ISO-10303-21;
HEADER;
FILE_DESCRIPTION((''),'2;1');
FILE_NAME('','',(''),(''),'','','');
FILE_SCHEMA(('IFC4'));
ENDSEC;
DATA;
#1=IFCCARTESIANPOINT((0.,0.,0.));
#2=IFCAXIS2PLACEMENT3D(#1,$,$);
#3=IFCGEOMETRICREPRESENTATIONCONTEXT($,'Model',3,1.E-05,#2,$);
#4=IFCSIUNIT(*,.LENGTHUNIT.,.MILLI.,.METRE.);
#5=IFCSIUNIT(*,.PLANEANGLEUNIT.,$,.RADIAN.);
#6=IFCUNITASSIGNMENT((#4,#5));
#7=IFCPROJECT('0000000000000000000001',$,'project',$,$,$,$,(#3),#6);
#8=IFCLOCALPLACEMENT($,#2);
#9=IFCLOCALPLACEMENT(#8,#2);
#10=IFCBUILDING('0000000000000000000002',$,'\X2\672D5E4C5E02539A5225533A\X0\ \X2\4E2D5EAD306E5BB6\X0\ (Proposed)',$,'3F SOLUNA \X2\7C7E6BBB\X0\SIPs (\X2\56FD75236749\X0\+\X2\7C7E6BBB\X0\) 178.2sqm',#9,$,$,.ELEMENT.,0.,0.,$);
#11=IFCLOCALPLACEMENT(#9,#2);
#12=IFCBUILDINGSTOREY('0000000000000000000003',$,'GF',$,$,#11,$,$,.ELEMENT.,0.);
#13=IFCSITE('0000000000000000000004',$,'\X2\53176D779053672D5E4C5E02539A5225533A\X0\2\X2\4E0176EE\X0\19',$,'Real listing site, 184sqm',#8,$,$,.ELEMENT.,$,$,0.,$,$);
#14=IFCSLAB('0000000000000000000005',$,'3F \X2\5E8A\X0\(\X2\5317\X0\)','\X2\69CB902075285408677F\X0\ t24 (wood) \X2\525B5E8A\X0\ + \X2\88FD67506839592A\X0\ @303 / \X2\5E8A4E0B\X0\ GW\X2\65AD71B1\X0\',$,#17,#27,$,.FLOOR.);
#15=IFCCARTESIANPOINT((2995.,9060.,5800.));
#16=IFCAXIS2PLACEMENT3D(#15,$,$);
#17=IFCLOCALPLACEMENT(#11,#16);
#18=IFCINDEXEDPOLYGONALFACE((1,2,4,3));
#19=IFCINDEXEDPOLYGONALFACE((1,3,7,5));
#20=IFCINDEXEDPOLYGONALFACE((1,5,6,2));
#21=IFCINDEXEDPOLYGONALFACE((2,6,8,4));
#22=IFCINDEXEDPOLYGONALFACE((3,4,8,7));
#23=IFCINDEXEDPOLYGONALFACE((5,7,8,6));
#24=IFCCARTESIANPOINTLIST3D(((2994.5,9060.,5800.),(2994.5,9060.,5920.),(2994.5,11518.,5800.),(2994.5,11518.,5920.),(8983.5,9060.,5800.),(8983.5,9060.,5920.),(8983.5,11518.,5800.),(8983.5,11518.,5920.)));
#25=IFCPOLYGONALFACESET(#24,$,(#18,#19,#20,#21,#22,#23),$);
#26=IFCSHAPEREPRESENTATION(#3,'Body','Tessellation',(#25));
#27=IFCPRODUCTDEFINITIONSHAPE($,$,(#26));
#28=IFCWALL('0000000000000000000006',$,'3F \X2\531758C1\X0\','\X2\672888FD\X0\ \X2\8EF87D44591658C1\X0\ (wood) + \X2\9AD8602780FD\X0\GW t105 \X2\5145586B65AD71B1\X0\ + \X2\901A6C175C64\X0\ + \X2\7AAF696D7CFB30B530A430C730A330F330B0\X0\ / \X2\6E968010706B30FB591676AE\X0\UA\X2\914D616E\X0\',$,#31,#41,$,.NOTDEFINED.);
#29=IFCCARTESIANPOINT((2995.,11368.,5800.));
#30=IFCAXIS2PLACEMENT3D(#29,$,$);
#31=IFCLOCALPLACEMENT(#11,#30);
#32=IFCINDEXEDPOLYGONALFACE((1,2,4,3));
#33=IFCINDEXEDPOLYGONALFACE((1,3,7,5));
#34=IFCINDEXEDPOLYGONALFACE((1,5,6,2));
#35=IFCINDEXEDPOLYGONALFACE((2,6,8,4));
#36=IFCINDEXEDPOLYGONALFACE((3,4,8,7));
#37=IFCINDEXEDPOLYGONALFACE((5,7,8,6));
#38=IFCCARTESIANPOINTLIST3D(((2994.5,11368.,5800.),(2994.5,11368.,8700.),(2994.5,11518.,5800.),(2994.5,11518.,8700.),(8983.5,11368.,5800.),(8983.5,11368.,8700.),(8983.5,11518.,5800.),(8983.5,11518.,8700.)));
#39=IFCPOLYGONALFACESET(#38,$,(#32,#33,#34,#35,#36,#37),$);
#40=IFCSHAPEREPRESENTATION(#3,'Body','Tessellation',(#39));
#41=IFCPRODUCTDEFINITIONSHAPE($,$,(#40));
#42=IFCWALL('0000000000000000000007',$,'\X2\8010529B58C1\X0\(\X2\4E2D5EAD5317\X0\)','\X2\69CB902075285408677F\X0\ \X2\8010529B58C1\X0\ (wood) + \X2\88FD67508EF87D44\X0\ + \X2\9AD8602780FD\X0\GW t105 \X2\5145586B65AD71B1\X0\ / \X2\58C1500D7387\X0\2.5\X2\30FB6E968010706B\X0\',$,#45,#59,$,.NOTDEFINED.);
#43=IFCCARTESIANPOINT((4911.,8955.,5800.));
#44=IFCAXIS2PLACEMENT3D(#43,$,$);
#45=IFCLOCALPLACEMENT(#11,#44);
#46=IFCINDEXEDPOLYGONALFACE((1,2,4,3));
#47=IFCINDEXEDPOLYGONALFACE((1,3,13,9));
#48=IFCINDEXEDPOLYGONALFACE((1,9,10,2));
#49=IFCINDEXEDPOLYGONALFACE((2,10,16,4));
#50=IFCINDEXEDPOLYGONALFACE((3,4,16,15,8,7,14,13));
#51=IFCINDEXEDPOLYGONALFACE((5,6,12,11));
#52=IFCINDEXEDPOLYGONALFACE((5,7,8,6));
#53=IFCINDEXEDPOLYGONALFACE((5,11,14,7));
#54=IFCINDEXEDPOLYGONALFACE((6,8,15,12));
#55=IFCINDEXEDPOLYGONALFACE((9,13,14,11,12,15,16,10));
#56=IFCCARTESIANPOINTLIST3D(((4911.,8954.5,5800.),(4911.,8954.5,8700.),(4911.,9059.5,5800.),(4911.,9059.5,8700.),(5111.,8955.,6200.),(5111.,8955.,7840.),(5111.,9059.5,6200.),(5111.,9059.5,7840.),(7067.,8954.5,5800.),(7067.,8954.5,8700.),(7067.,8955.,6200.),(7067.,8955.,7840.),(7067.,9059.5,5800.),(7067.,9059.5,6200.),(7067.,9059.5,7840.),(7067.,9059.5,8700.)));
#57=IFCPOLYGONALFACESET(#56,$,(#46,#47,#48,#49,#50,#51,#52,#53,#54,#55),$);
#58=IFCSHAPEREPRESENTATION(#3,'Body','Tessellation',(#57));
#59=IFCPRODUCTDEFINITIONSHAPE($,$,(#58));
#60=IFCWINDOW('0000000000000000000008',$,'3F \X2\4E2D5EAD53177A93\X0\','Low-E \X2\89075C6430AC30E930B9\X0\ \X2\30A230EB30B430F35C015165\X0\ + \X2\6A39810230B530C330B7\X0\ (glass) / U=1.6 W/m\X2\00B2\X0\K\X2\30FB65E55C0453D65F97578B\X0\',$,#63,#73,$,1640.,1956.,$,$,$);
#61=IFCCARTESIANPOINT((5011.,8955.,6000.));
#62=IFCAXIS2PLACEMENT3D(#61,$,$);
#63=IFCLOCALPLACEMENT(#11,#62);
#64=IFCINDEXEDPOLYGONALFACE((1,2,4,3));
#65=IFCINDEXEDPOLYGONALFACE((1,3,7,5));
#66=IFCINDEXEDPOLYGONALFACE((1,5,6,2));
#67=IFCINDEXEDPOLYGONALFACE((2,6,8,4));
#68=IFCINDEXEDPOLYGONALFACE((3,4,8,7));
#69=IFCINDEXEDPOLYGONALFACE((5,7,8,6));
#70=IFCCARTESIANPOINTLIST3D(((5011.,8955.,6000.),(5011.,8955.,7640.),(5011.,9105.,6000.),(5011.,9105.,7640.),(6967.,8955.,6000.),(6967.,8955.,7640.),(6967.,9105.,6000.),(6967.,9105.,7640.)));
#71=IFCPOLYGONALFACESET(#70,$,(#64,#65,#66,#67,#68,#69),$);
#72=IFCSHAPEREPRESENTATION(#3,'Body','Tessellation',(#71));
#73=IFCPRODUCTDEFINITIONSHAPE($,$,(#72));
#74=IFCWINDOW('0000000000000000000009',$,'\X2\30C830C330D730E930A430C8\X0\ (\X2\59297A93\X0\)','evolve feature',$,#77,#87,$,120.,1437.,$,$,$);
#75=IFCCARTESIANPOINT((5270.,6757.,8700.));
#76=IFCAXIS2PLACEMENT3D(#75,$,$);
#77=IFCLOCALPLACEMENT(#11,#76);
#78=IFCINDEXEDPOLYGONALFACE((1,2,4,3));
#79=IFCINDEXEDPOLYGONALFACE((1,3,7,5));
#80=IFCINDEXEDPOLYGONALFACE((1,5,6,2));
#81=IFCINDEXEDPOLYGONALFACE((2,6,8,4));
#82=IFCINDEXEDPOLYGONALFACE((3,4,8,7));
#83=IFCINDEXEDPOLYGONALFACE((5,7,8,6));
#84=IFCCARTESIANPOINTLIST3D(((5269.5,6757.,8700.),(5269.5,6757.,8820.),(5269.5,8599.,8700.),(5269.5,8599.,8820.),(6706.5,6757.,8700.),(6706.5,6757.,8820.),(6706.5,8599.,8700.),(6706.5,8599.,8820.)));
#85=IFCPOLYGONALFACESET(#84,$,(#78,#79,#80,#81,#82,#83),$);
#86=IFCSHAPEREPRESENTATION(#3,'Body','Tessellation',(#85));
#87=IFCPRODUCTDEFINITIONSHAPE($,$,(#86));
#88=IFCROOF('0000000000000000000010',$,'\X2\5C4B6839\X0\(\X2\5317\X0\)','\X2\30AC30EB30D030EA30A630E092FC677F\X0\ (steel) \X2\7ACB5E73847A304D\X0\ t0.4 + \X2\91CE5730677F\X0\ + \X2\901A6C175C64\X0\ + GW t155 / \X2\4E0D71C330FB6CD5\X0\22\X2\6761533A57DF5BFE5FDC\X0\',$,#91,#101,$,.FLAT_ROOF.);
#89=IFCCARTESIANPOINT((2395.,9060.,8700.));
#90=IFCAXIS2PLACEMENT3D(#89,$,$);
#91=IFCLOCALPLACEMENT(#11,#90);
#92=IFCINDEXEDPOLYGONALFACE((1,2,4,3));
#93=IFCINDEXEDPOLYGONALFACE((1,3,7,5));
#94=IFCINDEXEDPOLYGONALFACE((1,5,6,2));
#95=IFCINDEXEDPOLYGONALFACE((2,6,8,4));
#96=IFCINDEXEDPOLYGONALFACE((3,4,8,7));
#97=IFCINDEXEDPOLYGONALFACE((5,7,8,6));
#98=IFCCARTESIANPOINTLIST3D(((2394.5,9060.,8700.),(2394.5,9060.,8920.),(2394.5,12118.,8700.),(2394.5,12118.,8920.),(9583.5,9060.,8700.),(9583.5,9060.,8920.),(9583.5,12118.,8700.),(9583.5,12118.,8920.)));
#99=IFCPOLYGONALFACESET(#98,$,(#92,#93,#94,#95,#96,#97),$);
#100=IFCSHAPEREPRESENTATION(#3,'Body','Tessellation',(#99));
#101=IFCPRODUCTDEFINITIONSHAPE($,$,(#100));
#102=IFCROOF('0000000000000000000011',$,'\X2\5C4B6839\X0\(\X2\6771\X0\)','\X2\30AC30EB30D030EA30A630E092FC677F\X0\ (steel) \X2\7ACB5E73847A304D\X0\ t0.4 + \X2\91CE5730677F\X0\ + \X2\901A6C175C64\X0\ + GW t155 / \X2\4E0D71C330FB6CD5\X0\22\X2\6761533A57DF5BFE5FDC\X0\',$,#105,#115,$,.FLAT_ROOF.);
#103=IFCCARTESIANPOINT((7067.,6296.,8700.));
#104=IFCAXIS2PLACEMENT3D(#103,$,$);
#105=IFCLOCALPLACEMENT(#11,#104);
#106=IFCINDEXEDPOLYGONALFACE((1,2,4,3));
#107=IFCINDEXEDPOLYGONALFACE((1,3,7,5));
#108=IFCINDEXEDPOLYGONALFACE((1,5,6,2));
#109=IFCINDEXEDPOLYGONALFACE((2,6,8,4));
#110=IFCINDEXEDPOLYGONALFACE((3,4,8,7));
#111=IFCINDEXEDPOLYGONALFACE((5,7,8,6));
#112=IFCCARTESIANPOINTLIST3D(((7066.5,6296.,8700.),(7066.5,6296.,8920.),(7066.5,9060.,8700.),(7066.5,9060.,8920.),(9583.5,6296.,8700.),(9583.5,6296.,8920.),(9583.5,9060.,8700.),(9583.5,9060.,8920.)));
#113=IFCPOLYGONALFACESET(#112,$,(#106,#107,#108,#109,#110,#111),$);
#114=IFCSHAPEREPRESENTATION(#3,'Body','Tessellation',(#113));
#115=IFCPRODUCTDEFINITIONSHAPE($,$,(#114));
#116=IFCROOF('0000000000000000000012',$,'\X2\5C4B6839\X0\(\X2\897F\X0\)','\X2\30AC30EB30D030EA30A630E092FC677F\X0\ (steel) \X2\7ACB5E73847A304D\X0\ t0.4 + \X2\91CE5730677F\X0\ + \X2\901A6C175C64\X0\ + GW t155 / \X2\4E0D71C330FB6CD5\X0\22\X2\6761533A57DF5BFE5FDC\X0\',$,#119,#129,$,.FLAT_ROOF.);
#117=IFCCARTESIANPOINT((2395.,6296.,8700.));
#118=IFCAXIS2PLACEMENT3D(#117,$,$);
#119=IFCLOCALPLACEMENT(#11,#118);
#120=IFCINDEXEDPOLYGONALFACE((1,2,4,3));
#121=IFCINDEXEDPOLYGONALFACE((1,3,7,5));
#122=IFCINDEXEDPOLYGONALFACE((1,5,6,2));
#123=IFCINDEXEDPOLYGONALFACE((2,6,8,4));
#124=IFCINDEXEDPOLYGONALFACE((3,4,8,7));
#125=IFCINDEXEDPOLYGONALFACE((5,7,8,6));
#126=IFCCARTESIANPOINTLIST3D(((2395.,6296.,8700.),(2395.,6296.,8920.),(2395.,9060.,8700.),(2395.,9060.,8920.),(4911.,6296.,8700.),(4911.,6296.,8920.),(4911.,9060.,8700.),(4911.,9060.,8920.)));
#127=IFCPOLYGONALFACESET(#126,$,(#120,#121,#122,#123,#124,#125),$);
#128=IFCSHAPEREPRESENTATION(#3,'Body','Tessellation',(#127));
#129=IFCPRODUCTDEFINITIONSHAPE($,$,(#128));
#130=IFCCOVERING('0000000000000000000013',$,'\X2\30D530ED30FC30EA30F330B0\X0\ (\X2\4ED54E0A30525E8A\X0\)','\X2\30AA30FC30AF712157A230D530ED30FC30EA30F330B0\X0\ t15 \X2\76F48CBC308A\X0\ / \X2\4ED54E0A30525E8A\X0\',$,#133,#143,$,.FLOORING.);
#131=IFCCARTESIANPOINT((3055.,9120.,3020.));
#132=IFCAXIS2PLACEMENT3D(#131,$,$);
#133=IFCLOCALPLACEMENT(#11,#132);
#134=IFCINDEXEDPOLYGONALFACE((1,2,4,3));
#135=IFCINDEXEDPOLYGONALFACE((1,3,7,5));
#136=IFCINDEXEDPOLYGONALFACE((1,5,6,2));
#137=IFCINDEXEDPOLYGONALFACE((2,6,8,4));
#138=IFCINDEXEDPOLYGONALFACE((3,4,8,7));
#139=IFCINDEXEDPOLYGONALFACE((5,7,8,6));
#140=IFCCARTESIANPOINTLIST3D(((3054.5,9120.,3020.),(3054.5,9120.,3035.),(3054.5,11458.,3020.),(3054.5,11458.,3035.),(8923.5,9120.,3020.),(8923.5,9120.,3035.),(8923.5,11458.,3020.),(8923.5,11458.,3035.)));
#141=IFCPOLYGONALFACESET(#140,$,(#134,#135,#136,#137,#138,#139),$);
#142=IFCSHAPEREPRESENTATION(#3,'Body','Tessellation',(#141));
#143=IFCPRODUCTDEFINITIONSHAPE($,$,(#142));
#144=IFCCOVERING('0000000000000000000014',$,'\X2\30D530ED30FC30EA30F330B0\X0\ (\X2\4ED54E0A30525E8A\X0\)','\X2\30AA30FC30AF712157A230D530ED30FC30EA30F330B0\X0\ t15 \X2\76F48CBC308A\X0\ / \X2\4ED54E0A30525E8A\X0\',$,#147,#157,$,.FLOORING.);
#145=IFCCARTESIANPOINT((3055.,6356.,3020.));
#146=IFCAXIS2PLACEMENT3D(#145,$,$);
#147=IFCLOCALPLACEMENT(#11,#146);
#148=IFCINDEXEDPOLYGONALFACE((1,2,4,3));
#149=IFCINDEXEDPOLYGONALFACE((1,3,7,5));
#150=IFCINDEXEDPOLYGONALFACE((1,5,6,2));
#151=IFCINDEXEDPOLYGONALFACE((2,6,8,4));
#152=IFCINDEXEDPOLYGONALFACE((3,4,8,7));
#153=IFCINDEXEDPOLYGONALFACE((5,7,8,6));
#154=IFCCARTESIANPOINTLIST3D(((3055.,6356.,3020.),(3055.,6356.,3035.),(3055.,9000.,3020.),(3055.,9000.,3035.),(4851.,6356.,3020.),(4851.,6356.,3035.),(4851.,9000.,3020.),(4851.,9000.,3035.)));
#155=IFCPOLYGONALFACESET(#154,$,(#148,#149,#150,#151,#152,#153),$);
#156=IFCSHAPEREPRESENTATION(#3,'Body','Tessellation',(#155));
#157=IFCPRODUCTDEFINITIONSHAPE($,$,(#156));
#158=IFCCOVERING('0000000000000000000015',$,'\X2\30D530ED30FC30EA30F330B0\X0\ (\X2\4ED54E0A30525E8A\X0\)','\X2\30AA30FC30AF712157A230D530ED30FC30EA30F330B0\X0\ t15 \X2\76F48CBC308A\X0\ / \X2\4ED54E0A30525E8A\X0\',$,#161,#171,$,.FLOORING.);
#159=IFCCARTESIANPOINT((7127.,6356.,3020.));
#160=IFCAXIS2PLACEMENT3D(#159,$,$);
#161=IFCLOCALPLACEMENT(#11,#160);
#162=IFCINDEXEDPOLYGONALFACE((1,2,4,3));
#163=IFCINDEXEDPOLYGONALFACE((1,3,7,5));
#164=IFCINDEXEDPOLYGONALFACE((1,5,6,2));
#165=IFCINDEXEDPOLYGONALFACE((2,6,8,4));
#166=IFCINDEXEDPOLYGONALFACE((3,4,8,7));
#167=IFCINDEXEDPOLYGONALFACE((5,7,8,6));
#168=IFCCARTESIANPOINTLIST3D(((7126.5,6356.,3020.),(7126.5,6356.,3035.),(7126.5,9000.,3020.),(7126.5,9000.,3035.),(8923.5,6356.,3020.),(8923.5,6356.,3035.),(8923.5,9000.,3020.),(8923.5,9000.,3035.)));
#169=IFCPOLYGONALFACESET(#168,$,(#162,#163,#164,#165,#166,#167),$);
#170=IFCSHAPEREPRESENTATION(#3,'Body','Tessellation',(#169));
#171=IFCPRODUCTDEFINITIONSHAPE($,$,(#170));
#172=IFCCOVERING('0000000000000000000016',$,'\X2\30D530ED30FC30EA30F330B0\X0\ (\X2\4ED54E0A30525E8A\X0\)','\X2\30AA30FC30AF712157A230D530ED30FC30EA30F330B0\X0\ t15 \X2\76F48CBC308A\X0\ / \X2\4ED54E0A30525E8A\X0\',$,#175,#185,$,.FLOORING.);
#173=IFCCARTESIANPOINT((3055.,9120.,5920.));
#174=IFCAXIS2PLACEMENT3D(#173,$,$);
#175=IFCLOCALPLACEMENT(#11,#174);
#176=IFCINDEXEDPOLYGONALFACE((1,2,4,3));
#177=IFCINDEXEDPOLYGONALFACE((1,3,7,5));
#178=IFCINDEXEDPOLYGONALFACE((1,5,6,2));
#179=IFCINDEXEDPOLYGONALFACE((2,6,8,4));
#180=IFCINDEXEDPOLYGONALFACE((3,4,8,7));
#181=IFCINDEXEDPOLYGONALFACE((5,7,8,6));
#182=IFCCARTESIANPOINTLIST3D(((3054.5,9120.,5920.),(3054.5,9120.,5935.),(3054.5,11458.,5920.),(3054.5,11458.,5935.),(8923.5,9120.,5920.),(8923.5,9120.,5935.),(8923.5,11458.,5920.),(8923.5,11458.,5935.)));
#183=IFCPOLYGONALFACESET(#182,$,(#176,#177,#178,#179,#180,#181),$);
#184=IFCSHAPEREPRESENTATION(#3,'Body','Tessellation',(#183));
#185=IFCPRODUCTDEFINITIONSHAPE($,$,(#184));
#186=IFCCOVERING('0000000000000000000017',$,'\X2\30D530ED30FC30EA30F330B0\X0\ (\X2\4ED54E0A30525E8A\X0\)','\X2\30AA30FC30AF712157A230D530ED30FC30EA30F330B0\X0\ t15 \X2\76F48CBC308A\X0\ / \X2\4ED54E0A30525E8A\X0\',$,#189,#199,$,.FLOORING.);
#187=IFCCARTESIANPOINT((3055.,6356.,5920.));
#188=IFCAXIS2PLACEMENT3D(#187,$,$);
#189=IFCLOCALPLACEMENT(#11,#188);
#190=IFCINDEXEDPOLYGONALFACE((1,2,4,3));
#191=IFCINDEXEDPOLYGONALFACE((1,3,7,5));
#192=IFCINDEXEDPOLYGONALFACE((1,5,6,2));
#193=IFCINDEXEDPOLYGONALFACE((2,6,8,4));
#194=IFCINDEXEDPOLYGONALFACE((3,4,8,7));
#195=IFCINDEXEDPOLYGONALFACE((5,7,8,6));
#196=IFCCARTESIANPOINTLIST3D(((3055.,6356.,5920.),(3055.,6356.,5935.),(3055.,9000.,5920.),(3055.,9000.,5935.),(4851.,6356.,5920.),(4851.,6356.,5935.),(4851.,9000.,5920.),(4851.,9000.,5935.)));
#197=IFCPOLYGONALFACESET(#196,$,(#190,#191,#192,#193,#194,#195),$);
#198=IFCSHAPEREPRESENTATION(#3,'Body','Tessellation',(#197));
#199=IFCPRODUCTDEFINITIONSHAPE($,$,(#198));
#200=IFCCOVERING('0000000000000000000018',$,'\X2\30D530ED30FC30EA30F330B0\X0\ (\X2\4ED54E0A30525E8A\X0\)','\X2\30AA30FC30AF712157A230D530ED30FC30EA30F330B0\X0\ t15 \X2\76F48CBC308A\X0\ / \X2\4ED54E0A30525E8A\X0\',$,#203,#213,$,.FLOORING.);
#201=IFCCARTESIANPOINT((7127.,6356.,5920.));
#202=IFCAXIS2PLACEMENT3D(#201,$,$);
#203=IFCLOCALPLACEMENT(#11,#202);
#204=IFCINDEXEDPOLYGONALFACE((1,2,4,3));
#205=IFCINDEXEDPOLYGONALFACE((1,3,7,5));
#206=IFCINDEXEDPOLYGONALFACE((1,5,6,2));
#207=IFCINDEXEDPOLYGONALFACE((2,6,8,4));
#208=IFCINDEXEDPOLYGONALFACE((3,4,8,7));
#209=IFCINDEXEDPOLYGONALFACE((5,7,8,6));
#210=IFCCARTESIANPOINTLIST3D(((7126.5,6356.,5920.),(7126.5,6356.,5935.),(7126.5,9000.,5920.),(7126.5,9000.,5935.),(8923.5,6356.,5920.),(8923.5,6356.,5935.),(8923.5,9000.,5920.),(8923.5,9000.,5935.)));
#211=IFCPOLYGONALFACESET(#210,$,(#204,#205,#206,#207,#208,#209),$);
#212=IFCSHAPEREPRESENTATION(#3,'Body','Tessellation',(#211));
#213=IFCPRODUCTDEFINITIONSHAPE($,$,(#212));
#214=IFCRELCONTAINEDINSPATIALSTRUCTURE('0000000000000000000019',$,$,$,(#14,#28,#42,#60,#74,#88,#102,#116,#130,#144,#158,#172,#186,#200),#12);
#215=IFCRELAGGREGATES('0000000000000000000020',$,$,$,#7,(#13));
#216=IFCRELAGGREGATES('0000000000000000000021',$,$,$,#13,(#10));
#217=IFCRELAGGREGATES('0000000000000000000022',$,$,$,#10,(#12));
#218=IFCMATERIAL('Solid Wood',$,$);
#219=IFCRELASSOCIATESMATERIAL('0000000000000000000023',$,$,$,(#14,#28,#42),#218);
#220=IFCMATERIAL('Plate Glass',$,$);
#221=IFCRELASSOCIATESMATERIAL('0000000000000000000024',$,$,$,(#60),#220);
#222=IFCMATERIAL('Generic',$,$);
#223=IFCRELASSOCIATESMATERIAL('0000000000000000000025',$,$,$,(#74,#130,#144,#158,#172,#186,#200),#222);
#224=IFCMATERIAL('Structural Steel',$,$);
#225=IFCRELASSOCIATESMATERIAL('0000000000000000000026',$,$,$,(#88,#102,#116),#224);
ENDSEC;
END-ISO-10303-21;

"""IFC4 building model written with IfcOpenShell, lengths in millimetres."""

from ifc_helpers import new_model, si_unit, frame, frame_2d, origin, place, context, project, spatial, rectangle, extrude, material, element, fill, save


model = new_model("IFC4")

# Units and contexts
model_context = context("Model", 3, precision=1e-05, world=origin())
ifc_project = project(units=[si_unit("LENGTHUNIT", "METRE", prefix="MILLI"), si_unit("PLANEANGLEUNIT", "RADIAN")], contexts=[model_context])

# Site, building, storey
site_placement = place(None, origin())
site = spatial("IfcSite", under=ifc_project, at=site_placement, Name="北海道札幌市厚別区2丁目19", ObjectType="Real listing site, 184sqm", CompositionType="ELEMENT", RefElevation=0.0)
building_placement = place(site_placement, origin())
building = spatial("IfcBuilding", under=site, at=building_placement, Name="札幌市厚別区 中庭の家 (Proposed)", ObjectType="3F SOLUNA 籾殻SIPs (国産杉+籾殻) 178.2sqm", CompositionType="ELEMENT", ElevationOfRefHeight=0.0, ElevationOfTerrain=0.0)
storey_placement = place(building_placement, origin())
storey = spatial("IfcBuildingStorey", under=building, at=storey_placement, Name="GF", CompositionType="ELEMENT", Elevation=0.0)

# Slab
ifc_material_1 = material(Name="Solid Wood")
slab_placement = place(storey_placement, frame((2995.0, 9060.0, 5800.0)))
element("IfcSlab", 1, at=slab_placement, inside=storey, material=ifc_material_1, Name="3F 床(北)", Description="構造用合板 t24 (wood) 剛床 + 製材根太 @303 / 床下 GW断熱", PredefinedType="FLOOR", context=model_context, shape_type="SweptSolid", body=[
    extrude(rectangle(XDim=5989.0, YDim=2458.0, at=frame_2d((2994.0, 1229.0))), frame((2995.0, 9060.0, 5800.0)), (0.0, 0.0, 1.0), 120.0),
])

# Wall
wall_1_placement = place(storey_placement, frame((2995.0, 11368.0, 5800.0)))
element("IfcWall", 2, at=wall_1_placement, inside=storey, material=ifc_material_1, Name="3F 北壁", Description="木製 軸組外壁 (wood) + 高性能GW t105 充填断熱 + 通気層 + 窯業系サイディング / 準耐火・外皮UA配慮", PredefinedType="NOTDEFINED", context=model_context, shape_type="SweptSolid", body=[
    extrude(rectangle(XDim=5989.0, YDim=150.0, at=frame_2d((2994.0, 75.0))), frame((2995.0, 11368.0, 5800.0)), (0.0, 0.0, 1.0), 2900.0),
])

# Wall, opening, window
wall_2_placement = place(storey_placement, frame((4911.0, 8955.0, 5800.0)))
wall_2 = element("IfcWall", 3, at=wall_2_placement, inside=storey, material=ifc_material_1, Name="耐力壁(中庭北)", Description="構造用合板 耐力壁 (wood) + 製材軸組 + 高性能GW t105 充填断熱 / 壁倍率2.5・準耐火", PredefinedType="NOTDEFINED", context=model_context, shape_type="SweptSolid", body=[
    extrude(rectangle(XDim=2156.0, YDim=105.0, at=frame_2d((1078.0, 52.0))), frame((4911.0, 8955.0, 5800.0)), (0.0, 0.0, 1.0), 2900.0),
])
opening_placement = place(storey_placement, frame((5011.0, 8955.0, 6000.0)))
opening = element("IfcOpeningElement", 4, at=opening_placement, cuts=wall_2, PredefinedType="NOTDEFINED", context=model_context, shape_type="SweptSolid", body=[
    extrude(rectangle(XDim=1956.0, YDim=150.0, at=frame_2d((978.0, 75.0))), frame((5011.0, 8955.0, 6000.0)), (0.0, 0.0, 1.0), 1640.0),
])
ifc_material_2 = material(Name="Plate Glass")
window_1_placement = place(storey_placement, frame((5011.0, 8955.0, 6000.0)))
window_1 = element("IfcWindow", 5, at=window_1_placement, inside=storey, material=ifc_material_2, Name="3F 中庭北窓", Description="Low-E 複層ガラス アルゴン封入 + 樹脂サッシ (glass) / U=1.6 W/m²K・日射取得型", OverallHeight=1640.0, OverallWidth=1956.0, context=model_context, shape_type="SweptSolid", body=[
    extrude(rectangle(XDim=1956.0, YDim=150.0, at=frame_2d((978.0, 75.0))), frame((5011.0, 8955.0, 6000.0)), (0.0, 0.0, 1.0), 1640.0),
])
fill(opening, window_1)

# Window
ifc_material_3 = material(Name="Generic")
window_2_placement = place(storey_placement, frame((5270.0, 6757.0, 8700.0)))
element("IfcWindow", 6, at=window_2_placement, inside=storey, material=ifc_material_3, Name="トップライト (天窓)", Description="evolve feature", OverallHeight=120.0, OverallWidth=1437.0, context=model_context, shape_type="SweptSolid", body=[
    extrude(rectangle(XDim=1437.0, YDim=1842.0, at=frame_2d((718.0, 921.0))), frame((5270.0, 6757.0, 8700.0)), (0.0, 0.0, 1.0), 120.0),
])

# Roofs
ifc_material_4 = material(Name="Structural Steel")
roof_1_placement = place(storey_placement, frame((2395.0, 9060.0, 8700.0)))
element("IfcRoof", 7, at=roof_1_placement, inside=storey, material=ifc_material_4, Name="屋根(北)", Description="ガルバリウム鋼板 (steel) 立平葺き t0.4 + 野地板 + 通気層 + GW t155 / 不燃・法22条区域対応", PredefinedType="FLAT_ROOF", context=model_context, shape_type="SweptSolid", body=[
    extrude(rectangle(XDim=7189.0, YDim=3058.0, at=frame_2d((3594.0, 1529.0))), frame((2395.0, 9060.0, 8700.0)), (0.0, 0.0, 1.0), 220.0),
])
roof_2_placement = place(storey_placement, frame((7067.0, 6296.0, 8700.0)))
element("IfcRoof", 8, at=roof_2_placement, inside=storey, material=ifc_material_4, Name="屋根(東)", Description="ガルバリウム鋼板 (steel) 立平葺き t0.4 + 野地板 + 通気層 + GW t155 / 不燃・法22条区域対応", PredefinedType="FLAT_ROOF", context=model_context, shape_type="SweptSolid", body=[
    extrude(rectangle(XDim=2517.0, YDim=2764.0, at=frame_2d((1258.0, 1382.0))), frame((7067.0, 6296.0, 8700.0)), (0.0, 0.0, 1.0), 220.0),
])
roof_3_placement = place(storey_placement, frame((2395.0, 6296.0, 8700.0)))
element("IfcRoof", 9, at=roof_3_placement, inside=storey, material=ifc_material_4, Name="屋根(西)", Description="ガルバリウム鋼板 (steel) 立平葺き t0.4 + 野地板 + 通気層 + GW t155 / 不燃・法22条区域対応", PredefinedType="FLAT_ROOF", context=model_context, shape_type="SweptSolid", body=[
    extrude(rectangle(XDim=2516.0, YDim=2764.0, at=frame_2d((1258.0, 1382.0))), frame((2395.0, 6296.0, 8700.0)), (0.0, 0.0, 1.0), 220.0),
])

# Coverings
covering_1_placement = place(storey_placement, frame((3055.0, 9120.0, 3020.0)))
element("IfcCovering", 10, at=covering_1_placement, inside=storey, material=ifc_material_3, Name="フローリング (仕上げ床)", Description="オーク無垢フローリング t15 直貼り / 仕上げ床", PredefinedType="FLOORING", context=model_context, shape_type="SweptSolid", body=[
    extrude(rectangle(XDim=5869.0, YDim=2338.0, at=frame_2d((2934.0, 1169.0))), frame((3055.0, 9120.0, 3020.0)), (0.0, 0.0, 1.0), 15.0),
])
covering_2_placement = place(storey_placement, frame((3055.0, 6356.0, 3020.0)))
element("IfcCovering", 11, at=covering_2_placement, inside=storey, material=ifc_material_3, Name="フローリング (仕上げ床)", Description="オーク無垢フローリング t15 直貼り / 仕上げ床", PredefinedType="FLOORING", context=model_context, shape_type="SweptSolid", body=[
    extrude(rectangle(XDim=1796.0, YDim=2644.0, at=frame_2d((898.0, 1322.0))), frame((3055.0, 6356.0, 3020.0)), (0.0, 0.0, 1.0), 15.0),
])
covering_3_placement = place(storey_placement, frame((7127.0, 6356.0, 3020.0)))
element("IfcCovering", 12, at=covering_3_placement, inside=storey, material=ifc_material_3, Name="フローリング (仕上げ床)", Description="オーク無垢フローリング t15 直貼り / 仕上げ床", PredefinedType="FLOORING", context=model_context, shape_type="SweptSolid", body=[
    extrude(rectangle(XDim=1797.0, YDim=2644.0, at=frame_2d((898.0, 1322.0))), frame((7127.0, 6356.0, 3020.0)), (0.0, 0.0, 1.0), 15.0),
])
covering_4_placement = place(storey_placement, frame((3055.0, 9120.0, 5920.0)))
element("IfcCovering", 13, at=covering_4_placement, inside=storey, material=ifc_material_3, Name="フローリング (仕上げ床)", Description="オーク無垢フローリング t15 直貼り / 仕上げ床", PredefinedType="FLOORING", context=model_context, shape_type="SweptSolid", body=[
    extrude(rectangle(XDim=5869.0, YDim=2338.0, at=frame_2d((2934.0, 1169.0))), frame((3055.0, 9120.0, 5920.0)), (0.0, 0.0, 1.0), 15.0),
])
covering_5_placement = place(storey_placement, frame((3055.0, 6356.0, 5920.0)))
element("IfcCovering", 14, at=covering_5_placement, inside=storey, material=ifc_material_3, Name="フローリング (仕上げ床)", Description="オーク無垢フローリング t15 直貼り / 仕上げ床", PredefinedType="FLOORING", context=model_context, shape_type="SweptSolid", body=[
    extrude(rectangle(XDim=1796.0, YDim=2644.0, at=frame_2d((898.0, 1322.0))), frame((3055.0, 6356.0, 5920.0)), (0.0, 0.0, 1.0), 15.0),
])
covering_6_placement = place(storey_placement, frame((7127.0, 6356.0, 5920.0)))
element("IfcCovering", 15, at=covering_6_placement, inside=storey, material=ifc_material_3, Name="フローリング (仕上げ床)", Description="オーク無垢フローリング t15 直貼り / 仕上げ床", PredefinedType="FLOORING", context=model_context, shape_type="SweptSolid", body=[
    extrude(rectangle(XDim=1797.0, YDim=2644.0, at=frame_2d((898.0, 1322.0))), frame((7127.0, 6356.0, 5920.0)), (0.0, 0.0, 1.0), 15.0),
])

save(model, "model.ifc")
